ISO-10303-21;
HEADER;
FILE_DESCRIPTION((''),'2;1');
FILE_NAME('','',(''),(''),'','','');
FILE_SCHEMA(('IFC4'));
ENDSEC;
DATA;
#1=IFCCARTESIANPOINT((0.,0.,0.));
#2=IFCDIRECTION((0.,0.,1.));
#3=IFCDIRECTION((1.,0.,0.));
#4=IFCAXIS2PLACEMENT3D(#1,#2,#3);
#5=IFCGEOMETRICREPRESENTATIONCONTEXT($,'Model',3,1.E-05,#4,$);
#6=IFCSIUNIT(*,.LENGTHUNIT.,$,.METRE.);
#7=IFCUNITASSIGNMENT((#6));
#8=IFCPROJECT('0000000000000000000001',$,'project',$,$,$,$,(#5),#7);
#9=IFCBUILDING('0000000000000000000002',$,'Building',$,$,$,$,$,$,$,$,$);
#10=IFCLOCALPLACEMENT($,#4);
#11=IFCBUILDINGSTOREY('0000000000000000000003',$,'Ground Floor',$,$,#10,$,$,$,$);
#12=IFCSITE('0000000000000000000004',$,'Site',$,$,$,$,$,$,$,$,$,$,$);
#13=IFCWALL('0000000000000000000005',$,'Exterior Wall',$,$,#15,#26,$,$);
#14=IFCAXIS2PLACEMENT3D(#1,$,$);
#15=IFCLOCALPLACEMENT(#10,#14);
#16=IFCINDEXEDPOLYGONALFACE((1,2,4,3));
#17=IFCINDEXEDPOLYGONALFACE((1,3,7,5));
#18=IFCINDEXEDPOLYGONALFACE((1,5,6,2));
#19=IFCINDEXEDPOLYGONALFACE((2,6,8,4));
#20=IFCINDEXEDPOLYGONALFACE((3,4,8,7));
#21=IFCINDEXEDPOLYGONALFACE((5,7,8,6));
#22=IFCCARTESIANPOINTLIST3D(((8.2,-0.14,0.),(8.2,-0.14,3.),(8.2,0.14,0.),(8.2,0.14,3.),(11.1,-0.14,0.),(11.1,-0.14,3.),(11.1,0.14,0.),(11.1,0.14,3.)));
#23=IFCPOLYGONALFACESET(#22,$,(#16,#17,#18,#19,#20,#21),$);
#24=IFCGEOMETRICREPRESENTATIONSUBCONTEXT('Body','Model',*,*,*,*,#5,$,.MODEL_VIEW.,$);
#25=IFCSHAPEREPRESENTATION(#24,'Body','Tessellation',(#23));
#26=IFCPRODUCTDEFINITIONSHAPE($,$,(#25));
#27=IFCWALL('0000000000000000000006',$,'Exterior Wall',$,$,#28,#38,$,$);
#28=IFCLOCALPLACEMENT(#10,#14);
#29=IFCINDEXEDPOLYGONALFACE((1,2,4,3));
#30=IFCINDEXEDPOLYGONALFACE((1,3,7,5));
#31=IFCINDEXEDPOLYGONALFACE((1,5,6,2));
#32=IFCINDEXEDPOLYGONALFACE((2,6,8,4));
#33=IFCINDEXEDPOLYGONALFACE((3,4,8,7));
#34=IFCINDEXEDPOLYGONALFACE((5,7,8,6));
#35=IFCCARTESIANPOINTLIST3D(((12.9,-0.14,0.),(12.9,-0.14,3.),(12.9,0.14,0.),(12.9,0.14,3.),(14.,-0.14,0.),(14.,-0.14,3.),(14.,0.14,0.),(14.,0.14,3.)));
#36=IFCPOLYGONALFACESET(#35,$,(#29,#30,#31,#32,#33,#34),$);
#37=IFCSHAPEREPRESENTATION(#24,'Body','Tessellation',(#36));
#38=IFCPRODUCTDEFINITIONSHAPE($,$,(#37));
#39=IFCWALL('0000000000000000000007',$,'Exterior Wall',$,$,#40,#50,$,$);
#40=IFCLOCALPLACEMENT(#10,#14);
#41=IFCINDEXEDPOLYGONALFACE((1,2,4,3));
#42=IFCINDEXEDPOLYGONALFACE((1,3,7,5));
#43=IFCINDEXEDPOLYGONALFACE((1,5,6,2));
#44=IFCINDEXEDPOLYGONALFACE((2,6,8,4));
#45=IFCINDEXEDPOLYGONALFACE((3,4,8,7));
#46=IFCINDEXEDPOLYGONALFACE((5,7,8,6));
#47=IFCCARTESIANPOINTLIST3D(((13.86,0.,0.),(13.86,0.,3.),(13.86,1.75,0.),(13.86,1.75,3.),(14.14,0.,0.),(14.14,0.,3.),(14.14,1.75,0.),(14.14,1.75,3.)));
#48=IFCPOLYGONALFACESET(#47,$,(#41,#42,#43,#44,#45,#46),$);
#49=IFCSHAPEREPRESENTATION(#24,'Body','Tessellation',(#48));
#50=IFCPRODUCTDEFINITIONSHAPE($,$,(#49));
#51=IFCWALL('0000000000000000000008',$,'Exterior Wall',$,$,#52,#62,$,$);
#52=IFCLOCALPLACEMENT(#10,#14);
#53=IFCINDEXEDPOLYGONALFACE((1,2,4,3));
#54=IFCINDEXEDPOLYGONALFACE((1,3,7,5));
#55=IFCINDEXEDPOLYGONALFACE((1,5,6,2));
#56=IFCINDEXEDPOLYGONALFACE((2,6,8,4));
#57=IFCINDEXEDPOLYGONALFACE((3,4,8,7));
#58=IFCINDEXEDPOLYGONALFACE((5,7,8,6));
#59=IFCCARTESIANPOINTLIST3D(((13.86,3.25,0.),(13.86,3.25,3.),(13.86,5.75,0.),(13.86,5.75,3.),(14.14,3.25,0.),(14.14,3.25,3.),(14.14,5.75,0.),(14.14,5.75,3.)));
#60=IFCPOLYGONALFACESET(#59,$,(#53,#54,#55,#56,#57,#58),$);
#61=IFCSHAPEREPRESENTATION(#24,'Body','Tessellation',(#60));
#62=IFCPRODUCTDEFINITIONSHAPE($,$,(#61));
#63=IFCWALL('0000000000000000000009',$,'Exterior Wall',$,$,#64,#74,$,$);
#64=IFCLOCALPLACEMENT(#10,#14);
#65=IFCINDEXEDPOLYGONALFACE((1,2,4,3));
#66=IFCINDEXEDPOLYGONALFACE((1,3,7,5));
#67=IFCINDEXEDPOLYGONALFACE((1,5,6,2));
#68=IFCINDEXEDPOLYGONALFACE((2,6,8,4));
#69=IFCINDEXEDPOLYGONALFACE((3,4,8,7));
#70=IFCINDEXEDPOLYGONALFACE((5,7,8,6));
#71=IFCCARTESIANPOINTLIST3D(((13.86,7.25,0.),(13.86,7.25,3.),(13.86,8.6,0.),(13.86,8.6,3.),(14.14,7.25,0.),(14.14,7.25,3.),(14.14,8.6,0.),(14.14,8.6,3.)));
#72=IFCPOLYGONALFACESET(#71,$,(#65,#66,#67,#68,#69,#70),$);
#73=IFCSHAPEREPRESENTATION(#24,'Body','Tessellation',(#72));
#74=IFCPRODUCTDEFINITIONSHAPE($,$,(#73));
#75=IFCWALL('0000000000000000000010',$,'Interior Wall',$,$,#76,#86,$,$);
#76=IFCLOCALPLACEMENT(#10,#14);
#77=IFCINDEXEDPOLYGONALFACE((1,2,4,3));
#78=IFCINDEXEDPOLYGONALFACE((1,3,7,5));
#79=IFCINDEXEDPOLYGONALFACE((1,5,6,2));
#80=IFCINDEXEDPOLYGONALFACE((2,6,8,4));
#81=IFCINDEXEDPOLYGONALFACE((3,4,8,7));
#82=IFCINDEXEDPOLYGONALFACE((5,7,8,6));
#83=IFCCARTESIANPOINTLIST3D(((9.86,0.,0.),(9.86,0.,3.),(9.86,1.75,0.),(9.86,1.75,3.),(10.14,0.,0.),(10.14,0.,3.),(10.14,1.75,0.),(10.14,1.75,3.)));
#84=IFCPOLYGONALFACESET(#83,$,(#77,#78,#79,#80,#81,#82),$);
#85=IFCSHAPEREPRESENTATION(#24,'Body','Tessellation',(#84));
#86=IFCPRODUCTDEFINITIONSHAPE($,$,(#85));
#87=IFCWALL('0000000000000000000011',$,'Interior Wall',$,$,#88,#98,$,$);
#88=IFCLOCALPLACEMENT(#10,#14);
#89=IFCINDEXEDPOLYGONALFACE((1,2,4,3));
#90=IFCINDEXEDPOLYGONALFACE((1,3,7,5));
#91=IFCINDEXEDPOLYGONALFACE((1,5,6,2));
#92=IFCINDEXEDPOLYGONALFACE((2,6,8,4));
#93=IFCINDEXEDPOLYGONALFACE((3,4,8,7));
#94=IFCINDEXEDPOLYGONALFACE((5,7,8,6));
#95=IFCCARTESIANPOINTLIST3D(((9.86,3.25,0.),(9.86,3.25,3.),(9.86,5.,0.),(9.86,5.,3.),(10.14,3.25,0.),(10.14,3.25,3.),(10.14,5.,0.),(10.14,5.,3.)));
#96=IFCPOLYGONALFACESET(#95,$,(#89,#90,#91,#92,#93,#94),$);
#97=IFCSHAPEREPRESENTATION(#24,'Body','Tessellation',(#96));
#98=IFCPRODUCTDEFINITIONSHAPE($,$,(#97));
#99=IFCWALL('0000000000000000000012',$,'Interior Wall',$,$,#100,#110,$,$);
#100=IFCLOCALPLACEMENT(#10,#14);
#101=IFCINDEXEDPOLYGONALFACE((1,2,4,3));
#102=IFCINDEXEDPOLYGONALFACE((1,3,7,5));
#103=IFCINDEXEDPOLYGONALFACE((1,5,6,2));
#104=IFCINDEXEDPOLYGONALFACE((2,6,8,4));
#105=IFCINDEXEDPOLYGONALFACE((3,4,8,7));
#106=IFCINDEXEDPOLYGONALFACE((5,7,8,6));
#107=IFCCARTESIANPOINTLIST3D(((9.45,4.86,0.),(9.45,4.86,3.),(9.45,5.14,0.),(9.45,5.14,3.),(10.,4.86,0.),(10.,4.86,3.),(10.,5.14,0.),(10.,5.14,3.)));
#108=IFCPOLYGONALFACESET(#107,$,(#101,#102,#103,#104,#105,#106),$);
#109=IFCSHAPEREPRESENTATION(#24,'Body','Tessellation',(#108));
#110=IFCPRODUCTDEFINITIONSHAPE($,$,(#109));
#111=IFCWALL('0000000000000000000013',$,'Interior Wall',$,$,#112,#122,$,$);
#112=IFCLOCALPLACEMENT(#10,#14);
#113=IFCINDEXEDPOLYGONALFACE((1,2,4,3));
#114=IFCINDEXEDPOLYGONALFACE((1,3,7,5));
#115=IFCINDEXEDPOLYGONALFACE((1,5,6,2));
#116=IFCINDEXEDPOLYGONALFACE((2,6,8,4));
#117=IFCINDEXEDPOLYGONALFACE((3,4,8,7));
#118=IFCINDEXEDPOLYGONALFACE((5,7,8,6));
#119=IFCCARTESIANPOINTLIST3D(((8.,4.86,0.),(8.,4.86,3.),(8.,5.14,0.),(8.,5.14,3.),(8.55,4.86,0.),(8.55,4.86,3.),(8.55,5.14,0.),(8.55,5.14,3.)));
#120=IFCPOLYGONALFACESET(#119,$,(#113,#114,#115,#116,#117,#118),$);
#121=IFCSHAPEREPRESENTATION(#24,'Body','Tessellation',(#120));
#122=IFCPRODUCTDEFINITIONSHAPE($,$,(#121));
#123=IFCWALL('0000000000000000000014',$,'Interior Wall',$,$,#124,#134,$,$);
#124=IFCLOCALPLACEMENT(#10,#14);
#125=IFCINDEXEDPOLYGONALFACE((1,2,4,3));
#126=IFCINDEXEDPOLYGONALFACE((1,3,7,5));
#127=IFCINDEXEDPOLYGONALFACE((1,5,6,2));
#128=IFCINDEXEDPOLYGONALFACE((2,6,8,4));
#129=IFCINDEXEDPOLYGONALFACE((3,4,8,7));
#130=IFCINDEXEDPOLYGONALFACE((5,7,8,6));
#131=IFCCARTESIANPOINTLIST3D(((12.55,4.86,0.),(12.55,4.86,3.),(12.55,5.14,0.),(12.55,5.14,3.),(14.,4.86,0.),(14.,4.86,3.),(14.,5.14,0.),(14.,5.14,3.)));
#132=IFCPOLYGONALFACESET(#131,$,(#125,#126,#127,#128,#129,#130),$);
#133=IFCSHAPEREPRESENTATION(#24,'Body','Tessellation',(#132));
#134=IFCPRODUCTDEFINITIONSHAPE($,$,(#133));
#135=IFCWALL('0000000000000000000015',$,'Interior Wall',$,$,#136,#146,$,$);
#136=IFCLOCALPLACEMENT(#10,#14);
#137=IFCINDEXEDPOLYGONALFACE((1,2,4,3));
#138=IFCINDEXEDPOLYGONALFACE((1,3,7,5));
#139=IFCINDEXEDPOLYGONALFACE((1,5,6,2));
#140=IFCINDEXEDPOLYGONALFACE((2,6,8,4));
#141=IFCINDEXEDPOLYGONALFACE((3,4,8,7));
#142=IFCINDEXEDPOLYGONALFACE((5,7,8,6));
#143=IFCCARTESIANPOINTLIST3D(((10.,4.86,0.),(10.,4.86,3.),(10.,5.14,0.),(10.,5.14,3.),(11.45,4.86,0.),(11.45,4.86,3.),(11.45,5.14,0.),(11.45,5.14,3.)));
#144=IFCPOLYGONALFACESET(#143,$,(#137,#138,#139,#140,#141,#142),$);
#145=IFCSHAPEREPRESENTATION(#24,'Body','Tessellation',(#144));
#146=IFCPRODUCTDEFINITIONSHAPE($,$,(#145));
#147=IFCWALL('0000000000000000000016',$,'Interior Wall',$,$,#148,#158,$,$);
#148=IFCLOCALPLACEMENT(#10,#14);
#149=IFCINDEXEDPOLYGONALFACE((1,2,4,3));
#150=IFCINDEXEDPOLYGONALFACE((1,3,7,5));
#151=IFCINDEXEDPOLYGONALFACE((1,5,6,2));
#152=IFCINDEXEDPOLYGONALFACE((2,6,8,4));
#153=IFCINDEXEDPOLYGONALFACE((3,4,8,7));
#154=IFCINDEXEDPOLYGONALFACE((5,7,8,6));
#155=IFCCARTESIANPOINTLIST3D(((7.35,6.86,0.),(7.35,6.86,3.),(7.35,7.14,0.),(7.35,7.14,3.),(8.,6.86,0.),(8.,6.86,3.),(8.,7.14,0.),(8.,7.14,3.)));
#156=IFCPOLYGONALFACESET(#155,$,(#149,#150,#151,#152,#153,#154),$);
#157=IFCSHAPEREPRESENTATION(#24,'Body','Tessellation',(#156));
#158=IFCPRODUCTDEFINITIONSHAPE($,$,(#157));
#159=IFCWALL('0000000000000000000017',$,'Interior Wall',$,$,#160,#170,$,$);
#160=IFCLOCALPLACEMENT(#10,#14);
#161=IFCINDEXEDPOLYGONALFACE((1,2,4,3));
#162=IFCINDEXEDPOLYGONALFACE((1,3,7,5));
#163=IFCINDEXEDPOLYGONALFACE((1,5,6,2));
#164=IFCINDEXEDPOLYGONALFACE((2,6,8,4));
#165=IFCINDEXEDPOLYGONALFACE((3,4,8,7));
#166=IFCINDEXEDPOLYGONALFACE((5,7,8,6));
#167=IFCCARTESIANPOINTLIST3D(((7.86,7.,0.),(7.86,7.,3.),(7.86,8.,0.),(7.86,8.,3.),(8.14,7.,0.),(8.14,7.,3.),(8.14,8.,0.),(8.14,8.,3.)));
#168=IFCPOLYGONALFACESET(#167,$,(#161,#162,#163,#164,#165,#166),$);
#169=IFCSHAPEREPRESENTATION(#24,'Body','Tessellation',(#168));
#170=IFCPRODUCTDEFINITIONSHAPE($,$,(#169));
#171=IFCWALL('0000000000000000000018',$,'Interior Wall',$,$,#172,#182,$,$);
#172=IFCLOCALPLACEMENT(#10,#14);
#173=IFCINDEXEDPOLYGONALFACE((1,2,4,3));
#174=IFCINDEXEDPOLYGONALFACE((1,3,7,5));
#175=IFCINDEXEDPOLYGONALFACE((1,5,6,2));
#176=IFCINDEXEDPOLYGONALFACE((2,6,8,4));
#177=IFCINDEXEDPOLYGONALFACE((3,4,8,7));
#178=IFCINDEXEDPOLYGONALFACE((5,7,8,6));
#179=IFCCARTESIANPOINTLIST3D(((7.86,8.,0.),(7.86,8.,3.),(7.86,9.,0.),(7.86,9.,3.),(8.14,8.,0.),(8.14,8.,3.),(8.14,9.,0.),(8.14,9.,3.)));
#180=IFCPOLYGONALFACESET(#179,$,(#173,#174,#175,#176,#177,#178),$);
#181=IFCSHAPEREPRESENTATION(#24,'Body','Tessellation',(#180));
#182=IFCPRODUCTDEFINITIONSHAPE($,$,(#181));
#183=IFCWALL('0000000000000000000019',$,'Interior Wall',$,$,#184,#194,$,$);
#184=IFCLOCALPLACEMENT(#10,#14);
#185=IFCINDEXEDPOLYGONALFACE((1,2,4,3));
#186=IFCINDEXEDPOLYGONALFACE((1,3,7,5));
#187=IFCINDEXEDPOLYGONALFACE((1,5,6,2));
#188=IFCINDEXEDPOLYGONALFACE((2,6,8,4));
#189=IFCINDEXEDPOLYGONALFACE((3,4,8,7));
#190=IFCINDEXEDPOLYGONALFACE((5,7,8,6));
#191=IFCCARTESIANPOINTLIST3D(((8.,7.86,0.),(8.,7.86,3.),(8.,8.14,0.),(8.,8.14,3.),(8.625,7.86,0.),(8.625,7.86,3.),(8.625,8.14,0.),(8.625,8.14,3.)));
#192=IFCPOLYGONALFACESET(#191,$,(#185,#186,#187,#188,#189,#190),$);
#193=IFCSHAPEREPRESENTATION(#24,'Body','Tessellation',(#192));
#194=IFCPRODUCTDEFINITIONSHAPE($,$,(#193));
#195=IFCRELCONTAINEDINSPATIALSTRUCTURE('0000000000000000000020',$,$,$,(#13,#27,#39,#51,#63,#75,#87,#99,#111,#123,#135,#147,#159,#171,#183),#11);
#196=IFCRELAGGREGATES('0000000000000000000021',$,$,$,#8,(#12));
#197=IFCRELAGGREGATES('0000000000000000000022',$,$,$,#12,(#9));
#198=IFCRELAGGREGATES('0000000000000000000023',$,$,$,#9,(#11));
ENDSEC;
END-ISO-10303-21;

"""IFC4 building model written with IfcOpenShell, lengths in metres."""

from ifc_helpers import new_model, si_unit, frame, origin_with_axes, place, context, subcontext, project, spatial, indexed_curve, outline, extrude, element, save


model = new_model("IFC4")

# Units and contexts
model_context = context("Model", 3, precision=1e-05, world=origin_with_axes())
body_context = subcontext(model_context, "Body", "Model", "MODEL_VIEW")
ifc_project = project(units=[si_unit("LENGTHUNIT", "METRE")], contexts=[model_context])

# Site, building, storey
site = spatial("IfcSite", under=ifc_project, Name="Site")
building = spatial("IfcBuilding", under=site, Name="Building")
storey_placement = place(None, origin_with_axes())
storey = spatial("IfcBuildingStorey", under=building, at=storey_placement, Name="Ground Floor")

# Walls
wall_1_placement = place(storey_placement, frame((8.2, 0.0, 0.0), z_axis=(0.0, 0.0, 1.0), x_axis=(1.0, 0.0, 0.0)))
element("IfcWall", 1, at=wall_1_placement, inside=storey, Name="Exterior Wall", context=body_context, shape_type="SweptSolid", body=[
    extrude(outline(indexed_curve([(0.0, 0.0), (0.0, 0.28), (2.9, 0.28), (2.9, 0.0), (0.0, 0.0)], self_intersect=False)), frame((0.0, -0.14, 0.0), z_axis=(0.0, 0.0, 1.0), x_axis=(1.0, 0.0, 0.0)), (0.0, 0.0, 1.0), 3.0),
])
wall_2_placement = place(storey_placement, frame((12.9, 0.0, 0.0), z_axis=(0.0, 0.0, 1.0), x_axis=(1.0, 0.0, 0.0)))
element("IfcWall", 2, at=wall_2_placement, inside=storey, Name="Exterior Wall", context=body_context, shape_type="SweptSolid", body=[
    extrude(outline(indexed_curve([(0.0, 0.0), (0.0, 0.28), (1.1, 0.28), (1.1, 0.0), (0.0, 0.0)], self_intersect=False)), frame((0.0, -0.14, 0.0), z_axis=(0.0, 0.0, 1.0), x_axis=(1.0, 0.0, 0.0)), (0.0, 0.0, 1.0), 3.0),
])
wall_3_placement = place(storey_placement, frame((14.0, 0.0, 0.0), z_axis=(0.0, 0.0, 1.0), x_axis=(0.0, 1.0, 0.0)))
element("IfcWall", 3, at=wall_3_placement, inside=storey, Name="Exterior Wall", context=body_context, shape_type="SweptSolid", body=[
    extrude(outline(indexed_curve([(0.0, 0.0), (0.0, 0.28), (1.75, 0.28), (1.75, 0.0), (0.0, 0.0)], self_intersect=False)), frame((0.0, -0.14, 0.0), z_axis=(0.0, 0.0, 1.0), x_axis=(1.0, 0.0, 0.0)), (0.0, 0.0, 1.0), 3.0),
])
wall_4_placement = place(storey_placement, frame((14.0, 3.25, 0.0), z_axis=(0.0, 0.0, 1.0), x_axis=(0.0, 1.0, 0.0)))
element("IfcWall", 4, at=wall_4_placement, inside=storey, Name="Exterior Wall", context=body_context, shape_type="SweptSolid", body=[
    extrude(outline(indexed_curve([(0.0, 0.0), (0.0, 0.28), (2.5, 0.28), (2.5, 0.0), (0.0, 0.0)], self_intersect=False)), frame((0.0, -0.14, 0.0), z_axis=(0.0, 0.0, 1.0), x_axis=(1.0, 0.0, 0.0)), (0.0, 0.0, 1.0), 3.0),
])
wall_5_placement = place(storey_placement, frame((14.0, 7.25, 0.0), z_axis=(0.0, 0.0, 1.0), x_axis=(0.0, 1.0, 0.0)))
element("IfcWall", 5, at=wall_5_placement, inside=storey, Name="Exterior Wall", context=body_context, shape_type="SweptSolid", body=[
    extrude(outline(indexed_curve([(0.0, 0.0), (0.0, 0.28), (1.35, 0.28), (1.35, 0.0), (0.0, 0.0)], self_intersect=False)), frame((0.0, -0.14, 0.0), z_axis=(0.0, 0.0, 1.0), x_axis=(1.0, 0.0, 0.0)), (0.0, 0.0, 1.0), 3.0),
])
for number, where, z_axis, x_axis, name in (
    (6, (10.0, 0.0, 0.0), (0.0, 0.0, 1.0), (0.0, 1.0, 0.0), "Interior Wall"),
    (7, (10.0, 3.25, 0.0), (0.0, 0.0, 1.0), (0.0, 1.0, 0.0), "Interior Wall"),
):
    element("IfcWall", number, at=place(storey_placement, frame(where, z_axis=z_axis, x_axis=x_axis)), inside=storey, Name=name, context=body_context, shape_type="SweptSolid", body=[
        extrude(outline(indexed_curve([(0.0, 0.0), (0.0, 0.28), (1.75, 0.28), (1.75, 0.0), (0.0, 0.0)], self_intersect=False)), frame((0.0, -0.14, 0.0), z_axis=(0.0, 0.0, 1.0), x_axis=(1.0, 0.0, 0.0)), (0.0, 0.0, 1.0), 3.0),
    ])
for number, where, z_axis, x_axis, name in (
    (8, (10.0, 5.0, 0.0), (0.0, 0.0, 1.0), (-1.0, 0.0, 0.0), "Interior Wall"),
    (9, (8.55, 5.0, 0.0), (0.0, 0.0, 1.0), (-1.0, 0.0, 0.0), "Interior Wall"),
):
    element("IfcWall", number, at=place(storey_placement, frame(where, z_axis=z_axis, x_axis=x_axis)), inside=storey, Name=name, context=body_context, shape_type="SweptSolid", body=[
        extrude(outline(indexed_curve([(0.0, 0.0), (0.0, 0.28), (0.55, 0.28), (0.55, 0.0), (0.0, 0.0)], self_intersect=False)), frame((0.0, -0.14, 0.0), z_axis=(0.0, 0.0, 1.0), x_axis=(1.0, 0.0, 0.0)), (0.0, 0.0, 1.0), 3.0),
    ])
for number, where, z_axis, x_axis, name in (
    (10, (14.0, 5.0, 0.0), (0.0, 0.0, 1.0), (-1.0, 0.0, 0.0), "Interior Wall"),
    (11, (11.45, 5.0, 0.0), (0.0, 0.0, 1.0), (-1.0, 0.0, 0.0), "Interior Wall"),
):
    element("IfcWall", number, at=place(storey_placement, frame(where, z_axis=z_axis, x_axis=x_axis)), inside=storey, Name=name, context=body_context, shape_type="SweptSolid", body=[
        extrude(outline(indexed_curve([(0.0, 0.0), (0.0, 0.28), (1.45, 0.28), (1.45, 0.0), (0.0, 0.0)], self_intersect=False)), frame((0.0, -0.14, 0.0), z_axis=(0.0, 0.0, 1.0), x_axis=(1.0, 0.0, 0.0)), (0.0, 0.0, 1.0), 3.0),
    ])
wall_6_placement = place(storey_placement, frame((8.0, 7.0, 0.0), z_axis=(0.0, 0.0, 1.0), x_axis=(-1.0, 0.0, 0.0)))
element("IfcWall", 12, at=wall_6_placement, inside=storey, Name="Interior Wall", context=body_context, shape_type="SweptSolid", body=[
    extrude(outline(indexed_curve([(0.0, 0.0), (0.0, 0.28), (0.65, 0.28), (0.65, 0.0), (0.0, 0.0)], self_intersect=False)), frame((0.0, -0.14, 0.0), z_axis=(0.0, 0.0, 1.0), x_axis=(1.0, 0.0, 0.0)), (0.0, 0.0, 1.0), 3.0),
])
for number, where, z_axis, x_axis, name in (
    (13, (8.0, 7.0, 0.0), (0.0, 0.0, 1.0), (0.0, 1.0, 0.0), "Interior Wall"),
    (14, (8.0, 8.0, 0.0), (0.0, 0.0, 1.0), (0.0, 1.0, 0.0), "Interior Wall"),
):
    element("IfcWall", number, at=place(storey_placement, frame(where, z_axis=z_axis, x_axis=x_axis)), inside=storey, Name=name, context=body_context, shape_type="SweptSolid", body=[
        extrude(outline(indexed_curve([(0.0, 0.0), (0.0, 0.28), (1.0, 0.28), (1.0, 0.0), (0.0, 0.0)], self_intersect=False)), frame((0.0, -0.14, 0.0), z_axis=(0.0, 0.0, 1.0), x_axis=(1.0, 0.0, 0.0)), (0.0, 0.0, 1.0), 3.0),
    ])
wall_7_placement = place(storey_placement, frame((8.625, 8.0, 0.0), z_axis=(0.0, 0.0, 1.0), x_axis=(-1.0, 0.0, 0.0)))
element("IfcWall", 15, at=wall_7_placement, inside=storey, Name="Interior Wall", context=body_context, shape_type="SweptSolid", body=[
    extrude(outline(indexed_curve([(0.0, 0.0), (0.0, 0.28), (0.625, 0.28), (0.625, 0.0), (0.0, 0.0)], self_intersect=False)), frame((0.0, -0.14, 0.0), z_axis=(0.0, 0.0, 1.0), x_axis=(1.0, 0.0, 0.0)), (0.0, 0.0, 1.0), 3.0),
])

save(model, "model.ifc")
